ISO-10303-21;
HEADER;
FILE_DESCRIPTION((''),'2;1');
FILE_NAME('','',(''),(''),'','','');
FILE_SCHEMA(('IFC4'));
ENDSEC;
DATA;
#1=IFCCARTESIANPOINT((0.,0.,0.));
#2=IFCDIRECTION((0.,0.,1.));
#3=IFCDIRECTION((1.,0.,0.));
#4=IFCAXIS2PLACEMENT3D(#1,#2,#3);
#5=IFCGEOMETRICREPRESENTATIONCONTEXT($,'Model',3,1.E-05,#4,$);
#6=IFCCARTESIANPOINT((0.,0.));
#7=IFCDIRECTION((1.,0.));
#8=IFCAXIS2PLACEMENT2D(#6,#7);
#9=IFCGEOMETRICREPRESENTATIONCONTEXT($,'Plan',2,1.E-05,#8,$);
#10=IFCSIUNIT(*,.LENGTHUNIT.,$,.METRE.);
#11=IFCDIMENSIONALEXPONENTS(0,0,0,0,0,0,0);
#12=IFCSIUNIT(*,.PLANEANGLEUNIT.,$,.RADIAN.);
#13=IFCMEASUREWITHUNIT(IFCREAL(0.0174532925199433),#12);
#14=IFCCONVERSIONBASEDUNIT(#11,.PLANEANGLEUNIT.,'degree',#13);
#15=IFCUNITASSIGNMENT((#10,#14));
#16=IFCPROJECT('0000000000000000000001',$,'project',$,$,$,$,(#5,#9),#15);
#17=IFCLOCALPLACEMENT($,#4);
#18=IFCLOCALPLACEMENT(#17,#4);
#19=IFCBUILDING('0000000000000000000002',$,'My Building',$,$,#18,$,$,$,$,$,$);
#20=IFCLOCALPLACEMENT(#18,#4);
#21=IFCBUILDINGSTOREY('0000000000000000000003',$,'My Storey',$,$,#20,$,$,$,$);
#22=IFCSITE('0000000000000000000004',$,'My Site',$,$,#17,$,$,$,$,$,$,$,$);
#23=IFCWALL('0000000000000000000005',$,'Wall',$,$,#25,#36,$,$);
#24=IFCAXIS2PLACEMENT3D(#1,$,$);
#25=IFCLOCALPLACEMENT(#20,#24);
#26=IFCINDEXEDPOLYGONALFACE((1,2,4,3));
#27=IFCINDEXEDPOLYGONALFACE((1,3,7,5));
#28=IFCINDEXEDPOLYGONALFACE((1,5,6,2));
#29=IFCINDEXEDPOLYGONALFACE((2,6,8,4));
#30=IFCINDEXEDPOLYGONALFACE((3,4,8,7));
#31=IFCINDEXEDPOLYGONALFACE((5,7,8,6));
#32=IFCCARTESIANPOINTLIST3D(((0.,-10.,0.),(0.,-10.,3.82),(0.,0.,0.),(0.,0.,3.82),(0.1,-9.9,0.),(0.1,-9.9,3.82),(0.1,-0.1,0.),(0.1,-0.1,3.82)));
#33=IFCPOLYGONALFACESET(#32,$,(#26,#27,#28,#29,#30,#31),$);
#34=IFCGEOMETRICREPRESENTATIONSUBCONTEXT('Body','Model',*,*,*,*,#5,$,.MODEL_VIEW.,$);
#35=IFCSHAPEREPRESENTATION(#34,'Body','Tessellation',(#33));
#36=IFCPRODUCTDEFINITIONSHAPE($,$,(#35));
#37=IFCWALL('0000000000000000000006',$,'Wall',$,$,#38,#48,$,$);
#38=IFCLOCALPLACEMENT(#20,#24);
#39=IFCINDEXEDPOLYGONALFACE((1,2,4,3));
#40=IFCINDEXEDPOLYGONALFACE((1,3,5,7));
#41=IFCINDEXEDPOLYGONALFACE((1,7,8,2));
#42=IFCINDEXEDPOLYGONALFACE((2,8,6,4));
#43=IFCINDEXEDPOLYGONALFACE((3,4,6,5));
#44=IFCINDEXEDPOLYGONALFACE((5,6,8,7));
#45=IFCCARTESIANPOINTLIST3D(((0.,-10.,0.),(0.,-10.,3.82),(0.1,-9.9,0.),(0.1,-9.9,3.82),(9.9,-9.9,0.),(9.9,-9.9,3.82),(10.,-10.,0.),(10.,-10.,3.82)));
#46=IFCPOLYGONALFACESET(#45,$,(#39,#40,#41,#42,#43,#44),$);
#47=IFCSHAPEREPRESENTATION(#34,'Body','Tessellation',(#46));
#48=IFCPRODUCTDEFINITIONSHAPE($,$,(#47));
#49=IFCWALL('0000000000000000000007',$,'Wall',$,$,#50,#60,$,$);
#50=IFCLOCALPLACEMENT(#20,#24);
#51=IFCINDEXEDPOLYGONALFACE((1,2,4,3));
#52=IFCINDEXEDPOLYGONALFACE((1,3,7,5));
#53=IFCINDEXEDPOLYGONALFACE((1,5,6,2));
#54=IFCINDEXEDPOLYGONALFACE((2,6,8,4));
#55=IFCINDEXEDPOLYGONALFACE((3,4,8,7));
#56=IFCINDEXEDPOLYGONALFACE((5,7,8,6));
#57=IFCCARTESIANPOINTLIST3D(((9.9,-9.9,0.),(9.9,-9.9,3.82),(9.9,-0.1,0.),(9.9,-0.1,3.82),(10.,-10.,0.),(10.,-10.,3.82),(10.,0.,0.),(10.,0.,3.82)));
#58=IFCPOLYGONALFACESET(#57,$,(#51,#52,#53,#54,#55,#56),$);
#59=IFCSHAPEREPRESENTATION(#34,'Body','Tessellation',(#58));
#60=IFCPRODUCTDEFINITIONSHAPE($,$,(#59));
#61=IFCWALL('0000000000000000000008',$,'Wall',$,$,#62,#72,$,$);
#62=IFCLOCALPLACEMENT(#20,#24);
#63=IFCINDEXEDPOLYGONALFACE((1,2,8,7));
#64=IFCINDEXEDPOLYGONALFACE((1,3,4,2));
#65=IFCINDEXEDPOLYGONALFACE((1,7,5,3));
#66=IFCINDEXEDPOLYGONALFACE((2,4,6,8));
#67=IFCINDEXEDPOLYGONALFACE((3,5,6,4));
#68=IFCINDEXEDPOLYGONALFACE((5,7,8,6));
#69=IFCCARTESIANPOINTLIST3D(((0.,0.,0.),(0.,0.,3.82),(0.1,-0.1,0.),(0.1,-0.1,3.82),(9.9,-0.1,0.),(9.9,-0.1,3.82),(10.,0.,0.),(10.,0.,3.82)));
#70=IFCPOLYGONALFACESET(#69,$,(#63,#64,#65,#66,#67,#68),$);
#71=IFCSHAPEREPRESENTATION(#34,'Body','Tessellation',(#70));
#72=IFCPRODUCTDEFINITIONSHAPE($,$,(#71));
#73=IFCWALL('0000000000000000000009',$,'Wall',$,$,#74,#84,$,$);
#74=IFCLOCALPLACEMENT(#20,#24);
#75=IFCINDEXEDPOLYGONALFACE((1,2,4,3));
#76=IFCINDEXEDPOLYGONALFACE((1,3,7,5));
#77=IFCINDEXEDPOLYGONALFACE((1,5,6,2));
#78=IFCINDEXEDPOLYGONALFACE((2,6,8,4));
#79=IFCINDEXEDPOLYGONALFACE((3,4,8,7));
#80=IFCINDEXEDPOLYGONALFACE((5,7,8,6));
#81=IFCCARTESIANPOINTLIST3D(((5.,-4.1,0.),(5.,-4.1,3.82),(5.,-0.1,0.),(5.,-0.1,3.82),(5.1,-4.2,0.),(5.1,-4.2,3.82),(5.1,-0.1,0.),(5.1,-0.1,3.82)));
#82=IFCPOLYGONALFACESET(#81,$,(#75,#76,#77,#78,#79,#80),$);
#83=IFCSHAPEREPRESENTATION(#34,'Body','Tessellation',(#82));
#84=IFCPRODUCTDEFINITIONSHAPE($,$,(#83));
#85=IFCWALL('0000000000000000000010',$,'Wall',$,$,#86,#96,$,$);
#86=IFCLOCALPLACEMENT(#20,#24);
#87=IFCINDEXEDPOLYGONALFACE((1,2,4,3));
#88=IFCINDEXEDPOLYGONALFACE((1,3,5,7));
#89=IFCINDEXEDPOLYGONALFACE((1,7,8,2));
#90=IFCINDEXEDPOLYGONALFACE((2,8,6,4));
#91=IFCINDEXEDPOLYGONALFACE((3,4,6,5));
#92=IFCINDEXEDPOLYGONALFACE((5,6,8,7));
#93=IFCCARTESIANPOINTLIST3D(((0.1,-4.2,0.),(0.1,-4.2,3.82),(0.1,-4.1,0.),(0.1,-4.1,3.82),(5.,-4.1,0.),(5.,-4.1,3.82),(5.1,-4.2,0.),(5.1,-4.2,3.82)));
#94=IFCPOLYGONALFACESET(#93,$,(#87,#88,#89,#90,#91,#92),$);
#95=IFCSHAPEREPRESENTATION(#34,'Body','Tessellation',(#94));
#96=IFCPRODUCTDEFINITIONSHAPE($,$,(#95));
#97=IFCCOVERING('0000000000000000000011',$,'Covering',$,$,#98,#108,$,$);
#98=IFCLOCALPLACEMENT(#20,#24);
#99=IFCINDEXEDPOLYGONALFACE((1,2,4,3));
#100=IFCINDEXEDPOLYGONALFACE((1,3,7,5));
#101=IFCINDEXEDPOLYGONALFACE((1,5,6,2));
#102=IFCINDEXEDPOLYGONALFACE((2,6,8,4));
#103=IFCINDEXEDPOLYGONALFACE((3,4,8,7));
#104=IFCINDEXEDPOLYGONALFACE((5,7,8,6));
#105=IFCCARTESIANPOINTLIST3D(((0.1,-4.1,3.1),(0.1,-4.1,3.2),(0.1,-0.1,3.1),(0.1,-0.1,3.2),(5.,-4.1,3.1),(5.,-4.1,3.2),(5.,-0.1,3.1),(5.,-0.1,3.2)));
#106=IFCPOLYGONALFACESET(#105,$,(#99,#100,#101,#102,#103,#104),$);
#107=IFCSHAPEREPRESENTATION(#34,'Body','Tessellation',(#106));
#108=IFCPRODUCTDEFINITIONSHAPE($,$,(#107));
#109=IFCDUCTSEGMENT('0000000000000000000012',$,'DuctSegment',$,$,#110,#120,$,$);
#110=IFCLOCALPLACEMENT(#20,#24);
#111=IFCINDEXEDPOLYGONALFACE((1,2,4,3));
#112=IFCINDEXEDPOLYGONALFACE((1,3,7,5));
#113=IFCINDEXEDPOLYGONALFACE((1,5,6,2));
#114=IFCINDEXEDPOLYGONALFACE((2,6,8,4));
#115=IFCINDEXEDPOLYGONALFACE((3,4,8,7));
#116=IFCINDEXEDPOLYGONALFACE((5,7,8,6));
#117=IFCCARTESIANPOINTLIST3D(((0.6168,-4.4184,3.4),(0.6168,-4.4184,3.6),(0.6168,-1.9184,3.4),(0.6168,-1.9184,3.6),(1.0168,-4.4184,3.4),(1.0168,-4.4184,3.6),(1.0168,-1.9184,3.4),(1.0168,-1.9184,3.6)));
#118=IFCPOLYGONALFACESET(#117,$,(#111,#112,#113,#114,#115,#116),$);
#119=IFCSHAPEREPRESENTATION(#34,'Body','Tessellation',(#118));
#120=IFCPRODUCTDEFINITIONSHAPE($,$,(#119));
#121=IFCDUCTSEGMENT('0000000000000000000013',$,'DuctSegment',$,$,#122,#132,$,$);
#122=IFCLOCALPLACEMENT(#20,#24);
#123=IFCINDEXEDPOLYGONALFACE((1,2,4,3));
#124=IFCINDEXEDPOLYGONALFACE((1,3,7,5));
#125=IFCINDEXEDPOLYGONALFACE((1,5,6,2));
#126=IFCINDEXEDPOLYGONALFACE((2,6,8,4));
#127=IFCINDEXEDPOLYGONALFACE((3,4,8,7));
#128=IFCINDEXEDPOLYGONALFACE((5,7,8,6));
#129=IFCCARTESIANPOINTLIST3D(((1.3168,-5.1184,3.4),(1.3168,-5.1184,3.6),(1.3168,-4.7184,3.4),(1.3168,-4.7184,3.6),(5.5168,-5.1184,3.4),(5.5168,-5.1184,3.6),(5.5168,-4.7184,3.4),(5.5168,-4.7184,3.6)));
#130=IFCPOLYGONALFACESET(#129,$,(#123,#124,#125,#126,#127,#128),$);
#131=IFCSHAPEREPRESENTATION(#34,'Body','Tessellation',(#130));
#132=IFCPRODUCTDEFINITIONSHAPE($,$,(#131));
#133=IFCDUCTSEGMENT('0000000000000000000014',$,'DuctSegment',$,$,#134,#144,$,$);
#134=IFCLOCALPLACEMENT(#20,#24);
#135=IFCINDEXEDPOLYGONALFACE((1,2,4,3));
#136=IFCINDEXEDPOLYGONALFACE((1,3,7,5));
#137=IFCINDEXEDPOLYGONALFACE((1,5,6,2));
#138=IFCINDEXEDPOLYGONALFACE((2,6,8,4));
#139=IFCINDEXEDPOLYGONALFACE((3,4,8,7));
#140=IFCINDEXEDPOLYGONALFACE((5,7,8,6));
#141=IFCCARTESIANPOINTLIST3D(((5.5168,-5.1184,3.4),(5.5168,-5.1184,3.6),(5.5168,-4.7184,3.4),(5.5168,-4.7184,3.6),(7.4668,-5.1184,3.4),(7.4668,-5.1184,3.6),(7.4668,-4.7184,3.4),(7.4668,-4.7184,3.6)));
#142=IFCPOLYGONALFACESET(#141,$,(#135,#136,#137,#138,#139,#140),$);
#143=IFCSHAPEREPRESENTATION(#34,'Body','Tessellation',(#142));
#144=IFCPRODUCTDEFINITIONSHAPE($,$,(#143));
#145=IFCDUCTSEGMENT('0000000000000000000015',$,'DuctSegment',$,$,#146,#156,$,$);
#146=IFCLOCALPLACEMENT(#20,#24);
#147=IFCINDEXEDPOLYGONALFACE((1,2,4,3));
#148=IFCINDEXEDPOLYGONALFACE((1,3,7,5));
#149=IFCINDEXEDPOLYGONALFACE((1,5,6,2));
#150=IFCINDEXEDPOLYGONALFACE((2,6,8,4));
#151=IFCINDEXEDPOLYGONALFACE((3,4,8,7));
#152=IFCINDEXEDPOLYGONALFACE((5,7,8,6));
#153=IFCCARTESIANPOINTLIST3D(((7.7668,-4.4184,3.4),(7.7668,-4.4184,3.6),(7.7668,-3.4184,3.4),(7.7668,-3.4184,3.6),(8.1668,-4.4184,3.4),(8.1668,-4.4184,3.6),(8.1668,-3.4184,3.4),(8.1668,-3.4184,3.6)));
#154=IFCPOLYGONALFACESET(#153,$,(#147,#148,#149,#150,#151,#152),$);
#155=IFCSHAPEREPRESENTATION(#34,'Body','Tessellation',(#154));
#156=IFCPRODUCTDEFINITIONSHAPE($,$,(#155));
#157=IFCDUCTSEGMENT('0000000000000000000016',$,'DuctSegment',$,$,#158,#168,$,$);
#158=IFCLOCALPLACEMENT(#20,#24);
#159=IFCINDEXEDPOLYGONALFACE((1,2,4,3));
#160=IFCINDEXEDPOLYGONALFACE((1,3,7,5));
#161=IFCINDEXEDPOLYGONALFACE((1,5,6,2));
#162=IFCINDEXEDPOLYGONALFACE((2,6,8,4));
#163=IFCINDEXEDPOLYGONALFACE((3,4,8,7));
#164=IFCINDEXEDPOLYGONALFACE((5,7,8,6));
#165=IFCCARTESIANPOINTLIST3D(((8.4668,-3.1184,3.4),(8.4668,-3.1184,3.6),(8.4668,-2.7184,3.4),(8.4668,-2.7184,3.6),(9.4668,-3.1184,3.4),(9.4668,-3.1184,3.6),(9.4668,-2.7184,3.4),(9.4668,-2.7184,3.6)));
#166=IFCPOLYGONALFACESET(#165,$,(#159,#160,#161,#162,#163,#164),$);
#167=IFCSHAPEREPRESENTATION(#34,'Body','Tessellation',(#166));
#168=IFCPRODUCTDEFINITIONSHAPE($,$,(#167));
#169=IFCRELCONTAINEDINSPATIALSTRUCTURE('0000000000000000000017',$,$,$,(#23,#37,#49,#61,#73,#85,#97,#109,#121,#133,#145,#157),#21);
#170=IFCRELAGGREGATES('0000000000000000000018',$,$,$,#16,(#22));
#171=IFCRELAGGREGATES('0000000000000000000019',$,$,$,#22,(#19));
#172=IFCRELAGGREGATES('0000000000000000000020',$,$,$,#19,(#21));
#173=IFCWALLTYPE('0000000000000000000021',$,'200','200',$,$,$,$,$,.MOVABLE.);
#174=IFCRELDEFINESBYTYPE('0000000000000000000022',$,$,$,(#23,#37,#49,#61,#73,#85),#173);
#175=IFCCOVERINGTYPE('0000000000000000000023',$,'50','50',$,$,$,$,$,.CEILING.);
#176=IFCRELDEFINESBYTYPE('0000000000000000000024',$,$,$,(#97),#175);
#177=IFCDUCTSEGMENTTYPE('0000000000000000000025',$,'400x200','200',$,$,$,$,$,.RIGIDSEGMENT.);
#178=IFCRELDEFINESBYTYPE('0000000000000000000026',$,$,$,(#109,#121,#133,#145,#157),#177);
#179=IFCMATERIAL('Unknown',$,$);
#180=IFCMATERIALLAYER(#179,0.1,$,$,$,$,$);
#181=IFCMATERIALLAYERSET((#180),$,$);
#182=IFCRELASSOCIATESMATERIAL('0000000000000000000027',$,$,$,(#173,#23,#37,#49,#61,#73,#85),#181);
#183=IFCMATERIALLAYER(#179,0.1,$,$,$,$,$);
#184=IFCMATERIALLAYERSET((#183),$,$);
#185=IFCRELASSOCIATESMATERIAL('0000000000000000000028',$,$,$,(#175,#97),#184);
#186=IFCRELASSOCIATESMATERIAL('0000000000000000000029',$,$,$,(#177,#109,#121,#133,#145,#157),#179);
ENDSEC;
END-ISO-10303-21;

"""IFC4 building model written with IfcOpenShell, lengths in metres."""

from ifc_helpers import new_model, entity, si_unit, converted_unit, frame, origin_with_axes, origin_2d_with_axis, place, context, subcontext, project, spatial, line, indexed_curve, rectangle, outline, extrude, material, layer, layer_set, layer_usage, material_profile, profile_set, profile_usage, type_object, element, save


model = new_model("IFC4")

# Units and contexts
model_context = context("Model", 3, precision=1e-05, world=origin_with_axes())
plan_context = context("Plan", 2, precision=1e-05, world=origin_2d_with_axis())
body_context = subcontext(model_context, "Body", "Model", "MODEL_VIEW")
ifc_project = project(units=[si_unit("LENGTHUNIT", "METRE"), converted_unit("PLANEANGLEUNIT", "degree", entity("IfcReal", 0.0174532925199433), si_unit("PLANEANGLEUNIT", "RADIAN"), dimensions=[0, 0, 0, 0, 0, 0, 0])], contexts=[model_context, plan_context])

# Site, building, storey
site_placement = place(None, origin_with_axes())
site = spatial("IfcSite", under=ifc_project, at=site_placement, Name="My Site")
building_placement = place(site_placement, origin_with_axes())
building = spatial("IfcBuilding", under=site, at=building_placement, Name="My Building")
storey_placement = place(building_placement, origin_with_axes())
storey = spatial("IfcBuildingStorey", under=building, at=storey_placement, Name="My Storey")

# Walls
ifc_material = material(Name="Unknown")
ifc_layer_1 = layer(ifc_material, 0.1)
ifc_layer_set_1 = layer_set([ifc_layer_1])
ifc_layer_usage_1 = layer_usage(ifc_layer_set_1, "AXIS2", "POSITIVE", 0.0)
wall_type = type_object("IfcWallType", Name="200", Description="200", PredefinedType="MOVABLE", material=ifc_layer_set_1)
wall_1_placement = place(storey_placement, frame((0.0, 0.0, 0.0), z_axis=(0.0, 0.0, 1.0), x_axis=(0.0, -1.0, 0.0)))
element("IfcWall", 1, at=wall_1_placement, inside=storey, type_object=wall_type, material=ifc_layer_usage_1, Name="Wall", context=body_context, shape_type="SweptSolid", body=[
    extrude(outline(indexed_curve([(0.0, 0.0), (0.1, 0.1), (9.9, 0.1), (10.0, 0.0)], segments=[line(1, 2, 3, 4, 1)])), origin_with_axes(), (0.0, 0.0, 1.0), 3.82),
])
ifc_layer_usage_2 = layer_usage(ifc_layer_set_1, "AXIS2", "POSITIVE", 0.0)
wall_2_placement = place(storey_placement, frame((0.0, -10.0, 0.0), z_axis=(0.0, 0.0, 1.0), x_axis=(1.0, 0.0, 0.0)))
element("IfcWall", 2, at=wall_2_placement, inside=storey, type_object=wall_type, material=ifc_layer_usage_2, Name="Wall", context=body_context, shape_type="SweptSolid", body=[
    extrude(outline(indexed_curve([(0.0, 0.0), (0.1, 0.1), (9.9, 0.1), (10.0, 0.0)], segments=[line(1, 2, 3, 4, 1)])), origin_with_axes(), (0.0, 0.0, 1.0), 3.82),
])
ifc_layer_usage_3 = layer_usage(ifc_layer_set_1, "AXIS2", "POSITIVE", 0.0)
wall_3_placement = place(storey_placement, frame((10.0, -10.0, 0.0), z_axis=(0.0, 0.0, 1.0), x_axis=(0.0, 1.0, 0.0)))
element("IfcWall", 3, at=wall_3_placement, inside=storey, type_object=wall_type, material=ifc_layer_usage_3, Name="Wall", context=body_context, shape_type="SweptSolid", body=[
    extrude(outline(indexed_curve([(0.0, 0.0), (0.1, 0.1), (9.9, 0.1), (10.0, 0.0)], segments=[line(1, 2, 3, 4, 1)])), origin_with_axes(), (0.0, 0.0, 1.0), 3.82),
])
ifc_layer_usage_4 = layer_usage(ifc_layer_set_1, "AXIS2", "POSITIVE", 0.0)
wall_4_placement = place(storey_placement, frame((10.0, 0.0, 0.0), z_axis=(0.0, 0.0, 1.0), x_axis=(-1.0, 0.0, 0.0)))
element("IfcWall", 4, at=wall_4_placement, inside=storey, type_object=wall_type, material=ifc_layer_usage_4, Name="Wall", context=body_context, shape_type="SweptSolid", body=[
    extrude(outline(indexed_curve([(0.0, 0.0), (0.1, 0.1), (9.9, 0.1), (10.0, 0.0)], segments=[line(1, 2, 3, 4, 1)])), origin_with_axes(), (0.0, 0.0, 1.0), 3.82),
])
ifc_layer_usage_5 = layer_usage(ifc_layer_set_1, "AXIS2", "POSITIVE", 0.0)
wall_5_placement = place(storey_placement, frame((5.0, -0.1, 0.0), z_axis=(0.0, 0.0, 1.0), x_axis=(0.0, -1.0, 0.0)))
element("IfcWall", 5, at=wall_5_placement, inside=storey, type_object=wall_type, material=ifc_layer_usage_5, Name="Wall", context=body_context, shape_type="SweptSolid", body=[
    extrude(outline(indexed_curve([(0.0, 0.0), (0.0, 0.1), (4.1, 0.1), (4.0, 0.0)], segments=[line(1, 2, 3, 4, 1)])), origin_with_axes(), (0.0, 0.0, 1.0), 3.82),
])
ifc_layer_usage_6 = layer_usage(ifc_layer_set_1, "AXIS2", "POSITIVE", 0.0)
wall_6_placement = place(storey_placement, frame((5.0, -4.1, 0.0), z_axis=(0.0, 0.0, 1.0), x_axis=(-1.0, 0.0, 0.0)))
element("IfcWall", 6, at=wall_6_placement, inside=storey, type_object=wall_type, material=ifc_layer_usage_6, Name="Wall", context=body_context, shape_type="SweptSolid", body=[
    extrude(outline(indexed_curve([(0.0, 0.0), (-0.1, 0.1), (4.9, 0.1), (4.9, 0.0)], segments=[line(1, 2, 3, 4, 1)])), origin_with_axes(), (0.0, 0.0, 1.0), 3.82),
])

# Covering
ifc_layer_2 = layer(ifc_material, 0.1)
ifc_layer_set_2 = layer_set([ifc_layer_2])
ifc_layer_usage_7 = layer_usage(ifc_layer_set_2, "AXIS3", "POSITIVE", -0.1)
covering_type = type_object("IfcCoveringType", Name="50", Description="50", PredefinedType="CEILING", material=ifc_layer_set_2)
covering_placement = place(storey_placement, frame((0.1, -4.1, 3.2), z_axis=(0.0, 0.0, 1.0), x_axis=(1.0, 0.0, 0.0)))
element("IfcCovering", 7, at=covering_placement, inside=storey, type_object=covering_type, material=ifc_layer_usage_7, Name="Covering", context=body_context, shape_type="SweptSolid", body=[
    extrude(outline(indexed_curve([(0.0, 0.0), (4.9, 0.0), (4.9, 4.0), (0.0, 4.0), (0.0, 0.0)])), frame((0.0, 0.0, -0.1), z_axis=(0.0, 0.0, 1.0), x_axis=(1.0, 0.0, 0.0)), (0.0, 0.0, 1.0), 0.1),
])

# Duct segments
ifc_material_profile = material_profile(ifc_material, rectangle(XDim=0.4, YDim=0.2))
ifc_profile_set = profile_set([ifc_material_profile])
ifc_profile_usage_1 = profile_usage(ifc_profile_set, cardinal=5)
duct_segment_type = type_object("IfcDuctSegmentType", Name="400x200", Description="200", PredefinedType="RIGIDSEGMENT", material=ifc_profile_set)
duct_segment_1_placement = place(storey_placement, frame((0.8168, -1.9184, 3.5), z_axis=(0.0, -1.0, 0.0), x_axis=(1.0, 0.0, 0.0)))
element("IfcDuctSegment", 8, at=duct_segment_1_placement, inside=storey, type_object=duct_segment_type, material=ifc_profile_usage_1, Name="DuctSegment", context=body_context, shape_type="SweptSolid", body=[
    extrude(rectangle(XDim=0.4, YDim=0.2), origin_with_axes(), (0.0, 0.0, 1.0), 2.5),
])
ifc_profile_usage_2 = profile_usage(ifc_profile_set, cardinal=5)
duct_segment_2_placement = place(storey_placement, frame((1.3168, -4.9184, 3.5), z_axis=(1.0, 0.0, 0.000003), x_axis=(0.0, 1.0, 0.0)))
element("IfcDuctSegment", 9, at=duct_segment_2_placement, inside=storey, type_object=duct_segment_type, material=ifc_profile_usage_2, Name="DuctSegment", context=body_context, shape_type="SweptSolid", body=[
    extrude(rectangle(XDim=0.4, YDim=0.2), origin_with_axes(), (0.0, 0.0, 1.0), 4.2),
])
ifc_profile_usage_3 = profile_usage(ifc_profile_set, cardinal=5)
duct_segment_3_placement = place(storey_placement, frame((5.5168, -4.9184, 3.5), z_axis=(1.0, 0.0, 0.0), x_axis=(0.0, 1.0, 0.0)))
element("IfcDuctSegment", 10, at=duct_segment_3_placement, inside=storey, type_object=duct_segment_type, material=ifc_profile_usage_3, Name="DuctSegment", context=body_context, shape_type="SweptSolid", body=[
    extrude(rectangle(XDim=0.4, YDim=0.2), origin_with_axes(), (0.0, 0.0, 1.0), 1.95),
])
ifc_profile_usage_4 = profile_usage(ifc_profile_set, cardinal=5)
duct_segment_4_placement = place(storey_placement, frame((7.9668, -4.4184, 3.5), z_axis=(0.0, 1.0, -0.000006), x_axis=(-1.0, 0.0, 0.0)))
element("IfcDuctSegment", 11, at=duct_segment_4_placement, inside=storey, type_object=duct_segment_type, material=ifc_profile_usage_4, Name="DuctSegment", context=body_context, shape_type="SweptSolid", body=[
    extrude(rectangle(XDim=0.4, YDim=0.2), origin_with_axes(), (0.0, 0.0, 1.0), 1.0),
])
ifc_profile_usage_5 = profile_usage(ifc_profile_set, cardinal=5)
duct_segment_5_placement = place(storey_placement, frame((8.4668, -2.9184, 3.5), z_axis=(1.0, 0.0, -0.000001), x_axis=(0.0, 1.0, 0.0)))
element("IfcDuctSegment", 12, at=duct_segment_5_placement, inside=storey, type_object=duct_segment_type, material=ifc_profile_usage_5, Name="DuctSegment", context=body_context, shape_type="SweptSolid", body=[
    extrude(rectangle(XDim=0.4, YDim=0.2), origin_with_axes(), (0.0, 0.0, 1.0), 1.0),
])

save(model, "model.ifc")
